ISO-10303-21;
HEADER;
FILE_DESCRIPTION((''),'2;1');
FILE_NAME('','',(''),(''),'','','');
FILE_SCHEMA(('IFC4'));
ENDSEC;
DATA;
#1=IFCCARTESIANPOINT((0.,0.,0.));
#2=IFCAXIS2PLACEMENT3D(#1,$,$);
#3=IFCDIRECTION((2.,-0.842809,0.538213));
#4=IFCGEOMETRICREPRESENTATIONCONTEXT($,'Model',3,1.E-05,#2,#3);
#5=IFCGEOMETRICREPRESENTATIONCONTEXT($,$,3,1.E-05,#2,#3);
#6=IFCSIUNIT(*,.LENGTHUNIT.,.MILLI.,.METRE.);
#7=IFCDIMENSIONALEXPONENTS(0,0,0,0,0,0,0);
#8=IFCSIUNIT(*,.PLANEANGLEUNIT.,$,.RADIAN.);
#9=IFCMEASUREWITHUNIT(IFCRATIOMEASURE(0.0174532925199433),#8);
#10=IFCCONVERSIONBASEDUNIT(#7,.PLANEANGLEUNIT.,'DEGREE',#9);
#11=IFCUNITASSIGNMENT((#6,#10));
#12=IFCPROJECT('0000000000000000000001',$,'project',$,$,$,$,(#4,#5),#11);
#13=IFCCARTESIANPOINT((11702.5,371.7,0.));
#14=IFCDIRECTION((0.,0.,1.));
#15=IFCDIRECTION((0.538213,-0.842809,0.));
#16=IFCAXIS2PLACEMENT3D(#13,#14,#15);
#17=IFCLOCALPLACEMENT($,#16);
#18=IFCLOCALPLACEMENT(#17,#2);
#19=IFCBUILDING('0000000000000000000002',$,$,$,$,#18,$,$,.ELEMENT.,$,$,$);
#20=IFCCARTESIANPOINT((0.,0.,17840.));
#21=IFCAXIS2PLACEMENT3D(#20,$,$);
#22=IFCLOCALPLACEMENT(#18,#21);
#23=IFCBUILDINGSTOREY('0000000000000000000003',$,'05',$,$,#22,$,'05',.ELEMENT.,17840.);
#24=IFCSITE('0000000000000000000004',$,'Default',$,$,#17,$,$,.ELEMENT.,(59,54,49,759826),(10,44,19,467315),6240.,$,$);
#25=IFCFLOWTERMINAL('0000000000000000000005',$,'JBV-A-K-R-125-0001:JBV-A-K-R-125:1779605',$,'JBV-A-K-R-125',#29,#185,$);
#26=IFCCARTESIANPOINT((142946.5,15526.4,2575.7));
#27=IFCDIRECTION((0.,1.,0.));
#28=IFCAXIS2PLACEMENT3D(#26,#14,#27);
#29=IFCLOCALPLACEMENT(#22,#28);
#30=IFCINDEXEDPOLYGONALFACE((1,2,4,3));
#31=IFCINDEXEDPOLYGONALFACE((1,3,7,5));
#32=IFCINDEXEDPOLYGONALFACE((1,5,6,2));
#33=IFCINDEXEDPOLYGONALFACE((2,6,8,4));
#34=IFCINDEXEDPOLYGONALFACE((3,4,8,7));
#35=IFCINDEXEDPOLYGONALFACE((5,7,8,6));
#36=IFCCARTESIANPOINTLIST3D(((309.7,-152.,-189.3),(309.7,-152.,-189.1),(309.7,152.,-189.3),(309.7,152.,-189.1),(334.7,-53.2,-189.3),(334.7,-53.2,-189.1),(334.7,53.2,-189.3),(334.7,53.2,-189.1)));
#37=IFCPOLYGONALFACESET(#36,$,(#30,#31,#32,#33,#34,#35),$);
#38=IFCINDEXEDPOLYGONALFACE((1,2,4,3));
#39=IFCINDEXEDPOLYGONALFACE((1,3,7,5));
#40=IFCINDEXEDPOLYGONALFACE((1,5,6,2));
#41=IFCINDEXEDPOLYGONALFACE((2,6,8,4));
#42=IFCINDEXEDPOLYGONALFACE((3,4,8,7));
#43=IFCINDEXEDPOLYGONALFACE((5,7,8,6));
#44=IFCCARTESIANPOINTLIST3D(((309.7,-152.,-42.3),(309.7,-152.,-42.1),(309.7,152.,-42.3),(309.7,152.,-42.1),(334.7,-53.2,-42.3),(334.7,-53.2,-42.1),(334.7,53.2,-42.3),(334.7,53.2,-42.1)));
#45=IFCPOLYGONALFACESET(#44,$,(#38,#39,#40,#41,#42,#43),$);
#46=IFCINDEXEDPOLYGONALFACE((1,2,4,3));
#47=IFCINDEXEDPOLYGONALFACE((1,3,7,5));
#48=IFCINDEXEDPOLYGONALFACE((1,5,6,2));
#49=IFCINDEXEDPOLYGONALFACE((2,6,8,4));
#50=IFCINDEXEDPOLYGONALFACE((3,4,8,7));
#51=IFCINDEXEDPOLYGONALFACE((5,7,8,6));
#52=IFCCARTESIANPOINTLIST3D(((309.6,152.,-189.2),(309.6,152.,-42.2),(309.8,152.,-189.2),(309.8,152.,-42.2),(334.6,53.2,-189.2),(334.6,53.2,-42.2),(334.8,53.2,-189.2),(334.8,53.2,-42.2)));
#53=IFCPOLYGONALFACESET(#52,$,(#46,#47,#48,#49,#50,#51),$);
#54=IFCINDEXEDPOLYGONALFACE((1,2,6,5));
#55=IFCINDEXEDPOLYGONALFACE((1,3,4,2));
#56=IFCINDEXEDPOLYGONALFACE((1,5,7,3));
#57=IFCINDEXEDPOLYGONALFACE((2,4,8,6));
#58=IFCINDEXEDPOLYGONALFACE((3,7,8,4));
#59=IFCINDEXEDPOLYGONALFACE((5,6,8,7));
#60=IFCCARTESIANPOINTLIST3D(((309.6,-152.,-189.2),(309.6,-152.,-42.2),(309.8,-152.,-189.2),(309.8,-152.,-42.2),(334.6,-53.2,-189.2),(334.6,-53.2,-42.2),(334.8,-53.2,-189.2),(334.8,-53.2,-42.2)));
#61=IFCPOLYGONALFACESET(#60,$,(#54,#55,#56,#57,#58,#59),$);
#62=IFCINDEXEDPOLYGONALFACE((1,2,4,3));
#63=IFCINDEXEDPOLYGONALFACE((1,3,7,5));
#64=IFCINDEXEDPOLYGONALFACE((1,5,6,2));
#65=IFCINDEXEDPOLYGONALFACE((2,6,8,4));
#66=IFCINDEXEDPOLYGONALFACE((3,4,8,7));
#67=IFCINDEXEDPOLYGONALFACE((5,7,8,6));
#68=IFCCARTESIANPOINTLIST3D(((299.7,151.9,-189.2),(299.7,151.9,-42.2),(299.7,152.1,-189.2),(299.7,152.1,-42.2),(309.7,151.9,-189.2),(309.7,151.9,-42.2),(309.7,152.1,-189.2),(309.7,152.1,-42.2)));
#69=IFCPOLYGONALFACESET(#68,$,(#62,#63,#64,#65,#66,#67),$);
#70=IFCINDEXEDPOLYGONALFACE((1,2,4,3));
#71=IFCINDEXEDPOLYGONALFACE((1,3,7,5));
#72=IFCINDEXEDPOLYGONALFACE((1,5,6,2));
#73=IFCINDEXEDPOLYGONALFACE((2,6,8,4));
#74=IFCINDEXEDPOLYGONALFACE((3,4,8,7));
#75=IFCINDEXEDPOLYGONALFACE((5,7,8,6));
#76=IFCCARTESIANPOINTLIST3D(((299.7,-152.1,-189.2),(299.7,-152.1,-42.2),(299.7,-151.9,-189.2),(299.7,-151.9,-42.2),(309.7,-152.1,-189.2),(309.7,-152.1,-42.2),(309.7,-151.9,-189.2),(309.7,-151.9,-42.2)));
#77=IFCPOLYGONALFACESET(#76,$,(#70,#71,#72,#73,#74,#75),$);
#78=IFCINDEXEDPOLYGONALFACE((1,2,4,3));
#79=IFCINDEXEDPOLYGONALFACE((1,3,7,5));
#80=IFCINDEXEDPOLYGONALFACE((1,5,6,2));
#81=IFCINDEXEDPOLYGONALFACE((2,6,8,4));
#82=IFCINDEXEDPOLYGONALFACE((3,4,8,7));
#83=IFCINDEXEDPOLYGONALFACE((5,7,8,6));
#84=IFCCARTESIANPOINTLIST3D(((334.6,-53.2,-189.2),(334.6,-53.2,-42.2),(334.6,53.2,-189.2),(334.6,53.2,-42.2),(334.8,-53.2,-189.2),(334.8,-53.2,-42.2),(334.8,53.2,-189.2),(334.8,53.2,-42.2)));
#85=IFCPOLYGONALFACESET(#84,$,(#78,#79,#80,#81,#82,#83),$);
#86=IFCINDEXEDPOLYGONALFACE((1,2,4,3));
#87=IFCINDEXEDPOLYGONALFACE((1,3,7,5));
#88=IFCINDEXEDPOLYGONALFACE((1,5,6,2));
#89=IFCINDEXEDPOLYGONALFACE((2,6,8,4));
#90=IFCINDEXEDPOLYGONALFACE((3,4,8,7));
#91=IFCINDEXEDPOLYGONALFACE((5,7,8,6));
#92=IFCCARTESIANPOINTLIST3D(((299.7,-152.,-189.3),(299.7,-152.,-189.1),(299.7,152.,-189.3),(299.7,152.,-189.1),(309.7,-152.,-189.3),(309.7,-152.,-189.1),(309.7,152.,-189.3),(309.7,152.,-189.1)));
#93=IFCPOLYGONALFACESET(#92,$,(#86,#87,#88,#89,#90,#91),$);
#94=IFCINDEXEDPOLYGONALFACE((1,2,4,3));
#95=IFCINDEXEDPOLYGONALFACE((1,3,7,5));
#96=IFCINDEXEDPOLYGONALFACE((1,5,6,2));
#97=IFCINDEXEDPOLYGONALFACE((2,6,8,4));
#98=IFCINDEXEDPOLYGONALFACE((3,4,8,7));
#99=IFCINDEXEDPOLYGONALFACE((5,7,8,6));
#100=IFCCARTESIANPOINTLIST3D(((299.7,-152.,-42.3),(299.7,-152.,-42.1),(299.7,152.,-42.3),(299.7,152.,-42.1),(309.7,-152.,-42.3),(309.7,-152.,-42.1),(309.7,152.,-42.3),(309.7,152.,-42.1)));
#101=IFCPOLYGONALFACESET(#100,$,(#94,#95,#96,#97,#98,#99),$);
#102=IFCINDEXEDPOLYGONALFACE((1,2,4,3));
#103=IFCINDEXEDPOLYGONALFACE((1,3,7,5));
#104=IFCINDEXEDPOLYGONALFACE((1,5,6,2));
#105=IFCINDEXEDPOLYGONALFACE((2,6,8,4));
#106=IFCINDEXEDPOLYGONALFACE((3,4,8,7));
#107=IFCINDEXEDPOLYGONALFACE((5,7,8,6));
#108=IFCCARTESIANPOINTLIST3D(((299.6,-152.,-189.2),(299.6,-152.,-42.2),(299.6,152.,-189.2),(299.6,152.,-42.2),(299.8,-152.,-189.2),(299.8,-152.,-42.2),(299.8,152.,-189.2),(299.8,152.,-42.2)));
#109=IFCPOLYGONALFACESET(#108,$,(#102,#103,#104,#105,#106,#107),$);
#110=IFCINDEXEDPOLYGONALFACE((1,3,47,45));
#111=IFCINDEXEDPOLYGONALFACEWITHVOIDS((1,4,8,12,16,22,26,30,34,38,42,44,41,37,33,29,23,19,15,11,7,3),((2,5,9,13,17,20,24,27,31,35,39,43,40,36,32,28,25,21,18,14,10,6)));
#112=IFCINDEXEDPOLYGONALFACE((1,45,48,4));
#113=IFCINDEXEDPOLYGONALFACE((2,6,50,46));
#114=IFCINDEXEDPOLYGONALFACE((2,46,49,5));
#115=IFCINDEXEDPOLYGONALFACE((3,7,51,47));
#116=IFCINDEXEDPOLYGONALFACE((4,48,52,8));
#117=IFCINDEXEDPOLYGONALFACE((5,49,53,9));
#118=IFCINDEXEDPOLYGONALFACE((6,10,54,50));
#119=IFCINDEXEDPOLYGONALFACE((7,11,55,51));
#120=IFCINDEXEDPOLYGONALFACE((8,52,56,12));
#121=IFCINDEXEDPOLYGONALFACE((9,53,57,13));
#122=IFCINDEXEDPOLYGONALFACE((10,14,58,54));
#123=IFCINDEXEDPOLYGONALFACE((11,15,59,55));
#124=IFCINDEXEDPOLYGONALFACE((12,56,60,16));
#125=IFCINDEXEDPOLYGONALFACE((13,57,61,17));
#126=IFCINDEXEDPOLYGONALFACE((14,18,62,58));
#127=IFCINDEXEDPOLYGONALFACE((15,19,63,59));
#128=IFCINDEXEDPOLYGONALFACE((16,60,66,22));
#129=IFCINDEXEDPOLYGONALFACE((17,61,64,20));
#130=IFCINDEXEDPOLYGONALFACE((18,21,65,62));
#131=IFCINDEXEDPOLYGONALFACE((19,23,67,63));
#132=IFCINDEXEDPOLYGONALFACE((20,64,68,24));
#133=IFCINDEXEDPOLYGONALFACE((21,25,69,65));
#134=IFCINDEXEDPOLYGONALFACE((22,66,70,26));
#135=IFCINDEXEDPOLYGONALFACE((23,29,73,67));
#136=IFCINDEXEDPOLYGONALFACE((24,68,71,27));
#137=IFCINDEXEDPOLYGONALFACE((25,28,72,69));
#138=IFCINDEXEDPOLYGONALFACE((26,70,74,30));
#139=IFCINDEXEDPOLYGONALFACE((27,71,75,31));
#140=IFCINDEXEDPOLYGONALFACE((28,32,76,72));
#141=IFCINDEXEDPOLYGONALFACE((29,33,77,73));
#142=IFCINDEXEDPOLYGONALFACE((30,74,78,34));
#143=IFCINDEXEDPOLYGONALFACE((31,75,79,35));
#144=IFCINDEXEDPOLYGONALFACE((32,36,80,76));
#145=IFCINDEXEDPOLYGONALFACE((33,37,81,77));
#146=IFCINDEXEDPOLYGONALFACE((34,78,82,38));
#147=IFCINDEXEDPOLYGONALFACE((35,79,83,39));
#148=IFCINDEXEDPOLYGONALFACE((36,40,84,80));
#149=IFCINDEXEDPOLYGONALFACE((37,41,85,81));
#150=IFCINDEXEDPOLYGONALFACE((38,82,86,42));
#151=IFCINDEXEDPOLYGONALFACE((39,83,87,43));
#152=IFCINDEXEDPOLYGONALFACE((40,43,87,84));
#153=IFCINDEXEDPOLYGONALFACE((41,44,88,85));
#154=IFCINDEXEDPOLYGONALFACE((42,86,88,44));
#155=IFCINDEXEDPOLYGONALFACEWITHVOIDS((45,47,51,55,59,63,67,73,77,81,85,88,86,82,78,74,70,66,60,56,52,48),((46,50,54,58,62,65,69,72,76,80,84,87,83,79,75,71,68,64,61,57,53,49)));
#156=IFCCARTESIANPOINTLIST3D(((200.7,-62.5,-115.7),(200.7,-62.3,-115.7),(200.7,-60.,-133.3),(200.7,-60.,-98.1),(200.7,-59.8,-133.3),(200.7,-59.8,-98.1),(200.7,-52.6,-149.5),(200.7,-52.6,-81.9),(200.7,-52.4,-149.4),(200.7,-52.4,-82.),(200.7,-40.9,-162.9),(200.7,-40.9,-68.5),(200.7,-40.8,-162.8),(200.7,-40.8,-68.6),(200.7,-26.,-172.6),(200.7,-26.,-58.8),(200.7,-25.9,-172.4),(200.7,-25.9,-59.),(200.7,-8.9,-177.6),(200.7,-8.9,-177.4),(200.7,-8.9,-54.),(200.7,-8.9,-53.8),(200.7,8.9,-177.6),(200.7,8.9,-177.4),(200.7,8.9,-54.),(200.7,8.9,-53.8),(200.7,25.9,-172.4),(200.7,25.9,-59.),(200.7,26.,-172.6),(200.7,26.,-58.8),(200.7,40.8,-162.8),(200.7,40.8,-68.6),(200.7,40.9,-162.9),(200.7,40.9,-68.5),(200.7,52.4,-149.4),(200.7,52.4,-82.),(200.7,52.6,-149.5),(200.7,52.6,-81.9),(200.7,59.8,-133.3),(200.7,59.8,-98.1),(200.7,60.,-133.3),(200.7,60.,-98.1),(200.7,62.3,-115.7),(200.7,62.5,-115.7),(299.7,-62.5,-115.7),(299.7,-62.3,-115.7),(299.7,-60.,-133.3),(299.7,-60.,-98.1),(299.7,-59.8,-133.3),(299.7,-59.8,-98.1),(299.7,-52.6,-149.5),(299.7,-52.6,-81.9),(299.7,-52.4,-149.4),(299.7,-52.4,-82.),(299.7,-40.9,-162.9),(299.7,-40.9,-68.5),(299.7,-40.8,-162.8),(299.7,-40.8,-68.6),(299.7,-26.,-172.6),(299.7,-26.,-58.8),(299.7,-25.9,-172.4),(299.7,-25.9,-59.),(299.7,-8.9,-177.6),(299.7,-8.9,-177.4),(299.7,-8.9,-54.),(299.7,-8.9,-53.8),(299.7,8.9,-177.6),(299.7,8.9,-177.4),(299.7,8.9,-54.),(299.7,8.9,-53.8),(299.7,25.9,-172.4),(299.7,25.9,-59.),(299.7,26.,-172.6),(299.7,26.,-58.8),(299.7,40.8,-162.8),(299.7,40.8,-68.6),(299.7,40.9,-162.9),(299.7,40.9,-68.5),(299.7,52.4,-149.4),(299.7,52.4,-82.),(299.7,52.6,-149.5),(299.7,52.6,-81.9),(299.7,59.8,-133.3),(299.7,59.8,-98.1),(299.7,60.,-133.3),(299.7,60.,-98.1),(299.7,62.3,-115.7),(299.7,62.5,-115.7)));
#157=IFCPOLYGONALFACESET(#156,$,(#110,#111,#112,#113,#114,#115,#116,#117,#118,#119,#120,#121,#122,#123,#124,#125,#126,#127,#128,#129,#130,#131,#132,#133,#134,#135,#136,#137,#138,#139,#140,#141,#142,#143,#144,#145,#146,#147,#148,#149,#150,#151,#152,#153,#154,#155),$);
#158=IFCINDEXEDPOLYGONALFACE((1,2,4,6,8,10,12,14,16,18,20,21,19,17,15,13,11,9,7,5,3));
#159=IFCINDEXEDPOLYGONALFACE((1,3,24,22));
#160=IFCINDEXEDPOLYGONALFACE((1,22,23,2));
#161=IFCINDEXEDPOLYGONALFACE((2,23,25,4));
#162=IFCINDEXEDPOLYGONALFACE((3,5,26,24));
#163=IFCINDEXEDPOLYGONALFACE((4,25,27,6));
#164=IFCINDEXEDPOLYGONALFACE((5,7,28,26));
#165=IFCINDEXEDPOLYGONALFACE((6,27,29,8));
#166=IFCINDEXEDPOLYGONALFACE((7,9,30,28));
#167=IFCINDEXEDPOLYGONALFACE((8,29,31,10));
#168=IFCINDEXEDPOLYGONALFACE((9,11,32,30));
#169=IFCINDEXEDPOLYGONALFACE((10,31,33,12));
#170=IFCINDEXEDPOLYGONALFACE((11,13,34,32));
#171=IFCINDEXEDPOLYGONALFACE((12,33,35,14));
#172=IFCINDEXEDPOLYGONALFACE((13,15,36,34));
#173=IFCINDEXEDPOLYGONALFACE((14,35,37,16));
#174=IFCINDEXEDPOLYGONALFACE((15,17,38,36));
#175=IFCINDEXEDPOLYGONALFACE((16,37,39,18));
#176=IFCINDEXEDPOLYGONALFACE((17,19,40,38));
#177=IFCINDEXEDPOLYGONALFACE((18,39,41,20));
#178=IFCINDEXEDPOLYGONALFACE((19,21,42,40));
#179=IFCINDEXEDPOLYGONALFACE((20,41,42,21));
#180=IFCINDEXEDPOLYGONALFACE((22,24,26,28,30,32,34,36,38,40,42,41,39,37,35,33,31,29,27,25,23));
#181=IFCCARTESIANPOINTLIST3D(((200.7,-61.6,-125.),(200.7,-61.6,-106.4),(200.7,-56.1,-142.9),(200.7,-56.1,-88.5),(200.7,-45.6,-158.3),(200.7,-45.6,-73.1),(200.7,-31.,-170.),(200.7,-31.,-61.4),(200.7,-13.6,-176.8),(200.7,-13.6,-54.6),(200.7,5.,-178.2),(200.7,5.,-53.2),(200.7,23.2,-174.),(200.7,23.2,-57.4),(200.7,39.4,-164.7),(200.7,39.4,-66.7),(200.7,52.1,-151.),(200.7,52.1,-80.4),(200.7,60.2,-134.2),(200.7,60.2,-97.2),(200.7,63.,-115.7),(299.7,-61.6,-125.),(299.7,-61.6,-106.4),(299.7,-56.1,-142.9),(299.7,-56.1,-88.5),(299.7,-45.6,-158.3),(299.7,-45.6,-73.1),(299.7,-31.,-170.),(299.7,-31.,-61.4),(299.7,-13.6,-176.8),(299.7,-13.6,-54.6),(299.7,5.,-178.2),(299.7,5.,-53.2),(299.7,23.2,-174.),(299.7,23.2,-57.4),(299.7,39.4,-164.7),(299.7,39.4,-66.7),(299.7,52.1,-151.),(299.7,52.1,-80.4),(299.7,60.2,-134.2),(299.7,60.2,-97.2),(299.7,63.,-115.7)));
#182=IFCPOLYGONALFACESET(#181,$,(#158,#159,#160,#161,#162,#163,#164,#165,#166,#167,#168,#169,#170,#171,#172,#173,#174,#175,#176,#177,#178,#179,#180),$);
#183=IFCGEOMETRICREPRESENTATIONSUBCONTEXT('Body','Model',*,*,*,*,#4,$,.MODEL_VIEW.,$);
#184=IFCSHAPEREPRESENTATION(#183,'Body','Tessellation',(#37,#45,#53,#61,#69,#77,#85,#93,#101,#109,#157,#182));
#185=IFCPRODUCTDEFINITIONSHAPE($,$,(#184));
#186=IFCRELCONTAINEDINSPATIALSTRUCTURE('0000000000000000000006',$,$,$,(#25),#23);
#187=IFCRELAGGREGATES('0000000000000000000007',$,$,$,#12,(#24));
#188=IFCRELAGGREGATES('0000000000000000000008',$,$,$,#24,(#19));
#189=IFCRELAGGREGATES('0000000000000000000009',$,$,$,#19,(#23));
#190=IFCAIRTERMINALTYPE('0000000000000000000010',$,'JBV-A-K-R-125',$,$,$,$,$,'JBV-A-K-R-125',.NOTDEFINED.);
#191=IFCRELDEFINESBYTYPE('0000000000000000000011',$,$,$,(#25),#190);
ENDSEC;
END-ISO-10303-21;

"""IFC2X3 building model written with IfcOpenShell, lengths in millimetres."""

from ifc_helpers import new_model, entity, si_unit, converted_unit, direction, frame, frame_2d, origin, origin_2d_with_axis, place, context, subcontext, project, spatial, polyline, circle_curve, parameter, trimmed, segment, composite_curve, rectangle, circle, outline, extrude, source, transform, mapped, type_object, type_shapes, element, save


model = new_model("IFC2X3")

# Units and contexts
model_context = context("Model", 3, precision=1e-05, world=origin(), true_north=direction((2.0, -0.842809, 0.538213)))
context_of_model = context(None, 3, precision=1e-05, world=origin(), true_north=direction((2.0, -0.842809, 0.538213)))
body_context = subcontext(model_context, "Body", "Model", "MODEL_VIEW")
ifc_project = project(units=[si_unit("LENGTHUNIT", "METRE", prefix="MILLI"), converted_unit("PLANEANGLEUNIT", "DEGREE", entity("IfcRatioMeasure", 0.0174532925199433), si_unit("PLANEANGLEUNIT", "RADIAN"), dimensions=[0, 0, 0, 0, 0, 0, 0])], contexts=[model_context, context_of_model])

# Site, building, storey
site_placement = place(None, frame((11702.5, 371.7, 0.0), z_axis=(0.0, 0.0, 1.0), x_axis=(0.538213, -0.842809, 0.0)))
site = spatial("IfcSite", under=ifc_project, at=site_placement, Name="Default", CompositionType="ELEMENT", RefLatitude=(59, 54, 49, 759826), RefLongitude=(10, 44, 19, 467315), RefElevation=6240.0)
building_placement = place(site_placement, origin())
building = spatial("IfcBuilding", under=site, at=building_placement, CompositionType="ELEMENT")
storey_placement = place(building_placement, frame((0.0, 0.0, 17840.0)))
storey = spatial("IfcBuildingStorey", under=building, at=storey_placement, Name="05", LongName="05", CompositionType="ELEMENT", Elevation=17840.0)

# Flow terminal
air_terminal_type_1 = type_object("IfcAirTerminalType", Name="JBV-A-K-R-125", ElementType="JBV-A-K-R-125", PredefinedType="NOTDEFINED")
shared_shape_1 = source(origin(), body_context, "Body", "SweptSolid", [
    extrude(outline(polyline([(-152.0, -12.5), (152.0, -12.5), (53.2, 12.5), (-53.2, 12.5), (-152.0, -12.5)])), frame((322.2, 0.0, -189.3), z_axis=(0.0, 0.0, 1.0), x_axis=(0.0, -1.0, 0.0)), (0.0, 0.0, 1.0), 0.2),
    extrude(outline(polyline([(-152.0, -12.5), (152.0, -12.5), (53.2, 12.5), (-53.2, 12.5), (-152.0, -12.5)])), frame((322.2, 0.0, -42.3), z_axis=(0.0, 0.0, 1.0), x_axis=(0.0, -1.0, 0.0)), (0.0, 0.0, 1.0), 0.2),
    extrude(rectangle(XDim=0.2, YDim=101.9, at=frame_2d((0.0, 0.0), x_axis=(1.0, 0.0))), frame((322.2, 102.6, -189.2), z_axis=(0.0, 0.0, 1.0), x_axis=(0.969446, 0.245305, 0.0)), (0.0, 0.0, 1.0), 147.0),
    extrude(rectangle(XDim=0.2, YDim=101.9, at=frame_2d((0.0, 0.0), x_axis=(1.0, 0.0))), frame((322.2, -102.6, -189.2), z_axis=(0.0, 0.0, 1.0), x_axis=(-0.969446, 0.245305, 0.0)), (0.0, 0.0, 1.0), 147.0),
    extrude(rectangle(XDim=0.2, YDim=10.0, at=frame_2d((0.0, 0.0), x_axis=(1.0, 0.0))), frame((304.7, 152.0, -189.2), z_axis=(0.0, 0.0, 1.0), x_axis=(0.0, 1.0, 0.0)), (0.0, 0.0, 1.0), 147.0),
    extrude(rectangle(XDim=0.2, YDim=10.0, at=frame_2d((0.0, 0.0), x_axis=(1.0, 0.0))), frame((304.7, -152.0, -189.2), z_axis=(0.0, 0.0, 1.0), x_axis=(0.0, 1.0, 0.0)), (0.0, 0.0, 1.0), 147.0),
    extrude(rectangle(XDim=0.2, YDim=106.4, at=frame_2d((0.0, 0.0), x_axis=(1.0, 0.0))), frame((334.7, 0.0, -189.2)), (0.0, 0.0, 1.0), 147.0),
    extrude(rectangle(XDim=304.0, YDim=10.0, at=frame_2d((0.0, 0.0), x_axis=(1.0, 0.0))), frame((304.7, 0.0, -189.3), z_axis=(0.0, 0.0, 1.0), x_axis=(0.0, -1.0, 0.0)), (0.0, 0.0, 1.0), 0.2),
    extrude(rectangle(XDim=304.0, YDim=10.0, at=frame_2d((0.0, 0.0), x_axis=(1.0, 0.0))), frame((304.7, 0.0, -42.3), z_axis=(0.0, 0.0, 1.0), x_axis=(0.0, -1.0, 0.0)), (0.0, 0.0, 1.0), 0.2),
    extrude(rectangle(XDim=0.2, YDim=304.0, at=frame_2d((0.0, 0.0), x_axis=(1.0, 0.0))), frame((299.7, 0.0, -189.2)), (0.0, 0.0, 1.0), 147.0),
    extrude(outline(composite_curve([segment(trimmed(circle_curve(origin_2d_with_axis(), 62.5), [parameter(0.0)], [parameter(180.0)], True, "PARAMETER"), True, "CONTINUOUS"), segment(trimmed(circle_curve(origin_2d_with_axis(), 62.5), [parameter(180.0)], [parameter(360.0)], True, "PARAMETER"), True, "CONTINUOUS")], self_intersect=False), holes=[composite_curve([segment(trimmed(circle_curve(origin_2d_with_axis(), 62.3), [parameter(180.0)], [parameter(360.0)], True, "PARAMETER"), False, "CONTINUOUS"), segment(trimmed(circle_curve(origin_2d_with_axis(), 62.3), [parameter(0.0)], [parameter(180.0)], True, "PARAMETER"), False, "CONTINUOUS")], self_intersect=False)]), frame((200.7, 0.0, -115.7), z_axis=(1.0, 0.0, 0.0), x_axis=(0.0, 1.0, 0.0)), (0.0, 0.0, 1.0), 99.0),
    extrude(circle(Radius=62.6, at=frame_2d((0.0, 0.0), x_axis=(1.0, 0.0))), frame((200.7, 0.3, -115.7), z_axis=(1.0, 0.0, 0.0), x_axis=(0.0, 1.0, 0.0)), (0.0, 0.0, 1.0), 99.0),
])
type_shapes(air_terminal_type_1, [shared_shape_1])
for number, where, z_axis, x_axis, name in (
    (1, (142946.5, 15526.4, 2575.7), (0.0, 0.0, 1.0), (0.0, 1.0, 0.0), "JBV-A-K-R-125-0001:JBV-A-K-R-125:1779605"),
):
    element("IfcFlowTerminal", number, at=place(storey_placement, frame(where, z_axis=z_axis, x_axis=x_axis)), inside=storey, type_object=air_terminal_type_1, Name=name, ObjectType="JBV-A-K-R-125", context=body_context, shape_type="MappedRepresentation", body=[
        mapped(shared_shape_1, transform((0.0, 0.0, 0.0), scale=1.0)),
    ])

save(model, "model.ifc")
